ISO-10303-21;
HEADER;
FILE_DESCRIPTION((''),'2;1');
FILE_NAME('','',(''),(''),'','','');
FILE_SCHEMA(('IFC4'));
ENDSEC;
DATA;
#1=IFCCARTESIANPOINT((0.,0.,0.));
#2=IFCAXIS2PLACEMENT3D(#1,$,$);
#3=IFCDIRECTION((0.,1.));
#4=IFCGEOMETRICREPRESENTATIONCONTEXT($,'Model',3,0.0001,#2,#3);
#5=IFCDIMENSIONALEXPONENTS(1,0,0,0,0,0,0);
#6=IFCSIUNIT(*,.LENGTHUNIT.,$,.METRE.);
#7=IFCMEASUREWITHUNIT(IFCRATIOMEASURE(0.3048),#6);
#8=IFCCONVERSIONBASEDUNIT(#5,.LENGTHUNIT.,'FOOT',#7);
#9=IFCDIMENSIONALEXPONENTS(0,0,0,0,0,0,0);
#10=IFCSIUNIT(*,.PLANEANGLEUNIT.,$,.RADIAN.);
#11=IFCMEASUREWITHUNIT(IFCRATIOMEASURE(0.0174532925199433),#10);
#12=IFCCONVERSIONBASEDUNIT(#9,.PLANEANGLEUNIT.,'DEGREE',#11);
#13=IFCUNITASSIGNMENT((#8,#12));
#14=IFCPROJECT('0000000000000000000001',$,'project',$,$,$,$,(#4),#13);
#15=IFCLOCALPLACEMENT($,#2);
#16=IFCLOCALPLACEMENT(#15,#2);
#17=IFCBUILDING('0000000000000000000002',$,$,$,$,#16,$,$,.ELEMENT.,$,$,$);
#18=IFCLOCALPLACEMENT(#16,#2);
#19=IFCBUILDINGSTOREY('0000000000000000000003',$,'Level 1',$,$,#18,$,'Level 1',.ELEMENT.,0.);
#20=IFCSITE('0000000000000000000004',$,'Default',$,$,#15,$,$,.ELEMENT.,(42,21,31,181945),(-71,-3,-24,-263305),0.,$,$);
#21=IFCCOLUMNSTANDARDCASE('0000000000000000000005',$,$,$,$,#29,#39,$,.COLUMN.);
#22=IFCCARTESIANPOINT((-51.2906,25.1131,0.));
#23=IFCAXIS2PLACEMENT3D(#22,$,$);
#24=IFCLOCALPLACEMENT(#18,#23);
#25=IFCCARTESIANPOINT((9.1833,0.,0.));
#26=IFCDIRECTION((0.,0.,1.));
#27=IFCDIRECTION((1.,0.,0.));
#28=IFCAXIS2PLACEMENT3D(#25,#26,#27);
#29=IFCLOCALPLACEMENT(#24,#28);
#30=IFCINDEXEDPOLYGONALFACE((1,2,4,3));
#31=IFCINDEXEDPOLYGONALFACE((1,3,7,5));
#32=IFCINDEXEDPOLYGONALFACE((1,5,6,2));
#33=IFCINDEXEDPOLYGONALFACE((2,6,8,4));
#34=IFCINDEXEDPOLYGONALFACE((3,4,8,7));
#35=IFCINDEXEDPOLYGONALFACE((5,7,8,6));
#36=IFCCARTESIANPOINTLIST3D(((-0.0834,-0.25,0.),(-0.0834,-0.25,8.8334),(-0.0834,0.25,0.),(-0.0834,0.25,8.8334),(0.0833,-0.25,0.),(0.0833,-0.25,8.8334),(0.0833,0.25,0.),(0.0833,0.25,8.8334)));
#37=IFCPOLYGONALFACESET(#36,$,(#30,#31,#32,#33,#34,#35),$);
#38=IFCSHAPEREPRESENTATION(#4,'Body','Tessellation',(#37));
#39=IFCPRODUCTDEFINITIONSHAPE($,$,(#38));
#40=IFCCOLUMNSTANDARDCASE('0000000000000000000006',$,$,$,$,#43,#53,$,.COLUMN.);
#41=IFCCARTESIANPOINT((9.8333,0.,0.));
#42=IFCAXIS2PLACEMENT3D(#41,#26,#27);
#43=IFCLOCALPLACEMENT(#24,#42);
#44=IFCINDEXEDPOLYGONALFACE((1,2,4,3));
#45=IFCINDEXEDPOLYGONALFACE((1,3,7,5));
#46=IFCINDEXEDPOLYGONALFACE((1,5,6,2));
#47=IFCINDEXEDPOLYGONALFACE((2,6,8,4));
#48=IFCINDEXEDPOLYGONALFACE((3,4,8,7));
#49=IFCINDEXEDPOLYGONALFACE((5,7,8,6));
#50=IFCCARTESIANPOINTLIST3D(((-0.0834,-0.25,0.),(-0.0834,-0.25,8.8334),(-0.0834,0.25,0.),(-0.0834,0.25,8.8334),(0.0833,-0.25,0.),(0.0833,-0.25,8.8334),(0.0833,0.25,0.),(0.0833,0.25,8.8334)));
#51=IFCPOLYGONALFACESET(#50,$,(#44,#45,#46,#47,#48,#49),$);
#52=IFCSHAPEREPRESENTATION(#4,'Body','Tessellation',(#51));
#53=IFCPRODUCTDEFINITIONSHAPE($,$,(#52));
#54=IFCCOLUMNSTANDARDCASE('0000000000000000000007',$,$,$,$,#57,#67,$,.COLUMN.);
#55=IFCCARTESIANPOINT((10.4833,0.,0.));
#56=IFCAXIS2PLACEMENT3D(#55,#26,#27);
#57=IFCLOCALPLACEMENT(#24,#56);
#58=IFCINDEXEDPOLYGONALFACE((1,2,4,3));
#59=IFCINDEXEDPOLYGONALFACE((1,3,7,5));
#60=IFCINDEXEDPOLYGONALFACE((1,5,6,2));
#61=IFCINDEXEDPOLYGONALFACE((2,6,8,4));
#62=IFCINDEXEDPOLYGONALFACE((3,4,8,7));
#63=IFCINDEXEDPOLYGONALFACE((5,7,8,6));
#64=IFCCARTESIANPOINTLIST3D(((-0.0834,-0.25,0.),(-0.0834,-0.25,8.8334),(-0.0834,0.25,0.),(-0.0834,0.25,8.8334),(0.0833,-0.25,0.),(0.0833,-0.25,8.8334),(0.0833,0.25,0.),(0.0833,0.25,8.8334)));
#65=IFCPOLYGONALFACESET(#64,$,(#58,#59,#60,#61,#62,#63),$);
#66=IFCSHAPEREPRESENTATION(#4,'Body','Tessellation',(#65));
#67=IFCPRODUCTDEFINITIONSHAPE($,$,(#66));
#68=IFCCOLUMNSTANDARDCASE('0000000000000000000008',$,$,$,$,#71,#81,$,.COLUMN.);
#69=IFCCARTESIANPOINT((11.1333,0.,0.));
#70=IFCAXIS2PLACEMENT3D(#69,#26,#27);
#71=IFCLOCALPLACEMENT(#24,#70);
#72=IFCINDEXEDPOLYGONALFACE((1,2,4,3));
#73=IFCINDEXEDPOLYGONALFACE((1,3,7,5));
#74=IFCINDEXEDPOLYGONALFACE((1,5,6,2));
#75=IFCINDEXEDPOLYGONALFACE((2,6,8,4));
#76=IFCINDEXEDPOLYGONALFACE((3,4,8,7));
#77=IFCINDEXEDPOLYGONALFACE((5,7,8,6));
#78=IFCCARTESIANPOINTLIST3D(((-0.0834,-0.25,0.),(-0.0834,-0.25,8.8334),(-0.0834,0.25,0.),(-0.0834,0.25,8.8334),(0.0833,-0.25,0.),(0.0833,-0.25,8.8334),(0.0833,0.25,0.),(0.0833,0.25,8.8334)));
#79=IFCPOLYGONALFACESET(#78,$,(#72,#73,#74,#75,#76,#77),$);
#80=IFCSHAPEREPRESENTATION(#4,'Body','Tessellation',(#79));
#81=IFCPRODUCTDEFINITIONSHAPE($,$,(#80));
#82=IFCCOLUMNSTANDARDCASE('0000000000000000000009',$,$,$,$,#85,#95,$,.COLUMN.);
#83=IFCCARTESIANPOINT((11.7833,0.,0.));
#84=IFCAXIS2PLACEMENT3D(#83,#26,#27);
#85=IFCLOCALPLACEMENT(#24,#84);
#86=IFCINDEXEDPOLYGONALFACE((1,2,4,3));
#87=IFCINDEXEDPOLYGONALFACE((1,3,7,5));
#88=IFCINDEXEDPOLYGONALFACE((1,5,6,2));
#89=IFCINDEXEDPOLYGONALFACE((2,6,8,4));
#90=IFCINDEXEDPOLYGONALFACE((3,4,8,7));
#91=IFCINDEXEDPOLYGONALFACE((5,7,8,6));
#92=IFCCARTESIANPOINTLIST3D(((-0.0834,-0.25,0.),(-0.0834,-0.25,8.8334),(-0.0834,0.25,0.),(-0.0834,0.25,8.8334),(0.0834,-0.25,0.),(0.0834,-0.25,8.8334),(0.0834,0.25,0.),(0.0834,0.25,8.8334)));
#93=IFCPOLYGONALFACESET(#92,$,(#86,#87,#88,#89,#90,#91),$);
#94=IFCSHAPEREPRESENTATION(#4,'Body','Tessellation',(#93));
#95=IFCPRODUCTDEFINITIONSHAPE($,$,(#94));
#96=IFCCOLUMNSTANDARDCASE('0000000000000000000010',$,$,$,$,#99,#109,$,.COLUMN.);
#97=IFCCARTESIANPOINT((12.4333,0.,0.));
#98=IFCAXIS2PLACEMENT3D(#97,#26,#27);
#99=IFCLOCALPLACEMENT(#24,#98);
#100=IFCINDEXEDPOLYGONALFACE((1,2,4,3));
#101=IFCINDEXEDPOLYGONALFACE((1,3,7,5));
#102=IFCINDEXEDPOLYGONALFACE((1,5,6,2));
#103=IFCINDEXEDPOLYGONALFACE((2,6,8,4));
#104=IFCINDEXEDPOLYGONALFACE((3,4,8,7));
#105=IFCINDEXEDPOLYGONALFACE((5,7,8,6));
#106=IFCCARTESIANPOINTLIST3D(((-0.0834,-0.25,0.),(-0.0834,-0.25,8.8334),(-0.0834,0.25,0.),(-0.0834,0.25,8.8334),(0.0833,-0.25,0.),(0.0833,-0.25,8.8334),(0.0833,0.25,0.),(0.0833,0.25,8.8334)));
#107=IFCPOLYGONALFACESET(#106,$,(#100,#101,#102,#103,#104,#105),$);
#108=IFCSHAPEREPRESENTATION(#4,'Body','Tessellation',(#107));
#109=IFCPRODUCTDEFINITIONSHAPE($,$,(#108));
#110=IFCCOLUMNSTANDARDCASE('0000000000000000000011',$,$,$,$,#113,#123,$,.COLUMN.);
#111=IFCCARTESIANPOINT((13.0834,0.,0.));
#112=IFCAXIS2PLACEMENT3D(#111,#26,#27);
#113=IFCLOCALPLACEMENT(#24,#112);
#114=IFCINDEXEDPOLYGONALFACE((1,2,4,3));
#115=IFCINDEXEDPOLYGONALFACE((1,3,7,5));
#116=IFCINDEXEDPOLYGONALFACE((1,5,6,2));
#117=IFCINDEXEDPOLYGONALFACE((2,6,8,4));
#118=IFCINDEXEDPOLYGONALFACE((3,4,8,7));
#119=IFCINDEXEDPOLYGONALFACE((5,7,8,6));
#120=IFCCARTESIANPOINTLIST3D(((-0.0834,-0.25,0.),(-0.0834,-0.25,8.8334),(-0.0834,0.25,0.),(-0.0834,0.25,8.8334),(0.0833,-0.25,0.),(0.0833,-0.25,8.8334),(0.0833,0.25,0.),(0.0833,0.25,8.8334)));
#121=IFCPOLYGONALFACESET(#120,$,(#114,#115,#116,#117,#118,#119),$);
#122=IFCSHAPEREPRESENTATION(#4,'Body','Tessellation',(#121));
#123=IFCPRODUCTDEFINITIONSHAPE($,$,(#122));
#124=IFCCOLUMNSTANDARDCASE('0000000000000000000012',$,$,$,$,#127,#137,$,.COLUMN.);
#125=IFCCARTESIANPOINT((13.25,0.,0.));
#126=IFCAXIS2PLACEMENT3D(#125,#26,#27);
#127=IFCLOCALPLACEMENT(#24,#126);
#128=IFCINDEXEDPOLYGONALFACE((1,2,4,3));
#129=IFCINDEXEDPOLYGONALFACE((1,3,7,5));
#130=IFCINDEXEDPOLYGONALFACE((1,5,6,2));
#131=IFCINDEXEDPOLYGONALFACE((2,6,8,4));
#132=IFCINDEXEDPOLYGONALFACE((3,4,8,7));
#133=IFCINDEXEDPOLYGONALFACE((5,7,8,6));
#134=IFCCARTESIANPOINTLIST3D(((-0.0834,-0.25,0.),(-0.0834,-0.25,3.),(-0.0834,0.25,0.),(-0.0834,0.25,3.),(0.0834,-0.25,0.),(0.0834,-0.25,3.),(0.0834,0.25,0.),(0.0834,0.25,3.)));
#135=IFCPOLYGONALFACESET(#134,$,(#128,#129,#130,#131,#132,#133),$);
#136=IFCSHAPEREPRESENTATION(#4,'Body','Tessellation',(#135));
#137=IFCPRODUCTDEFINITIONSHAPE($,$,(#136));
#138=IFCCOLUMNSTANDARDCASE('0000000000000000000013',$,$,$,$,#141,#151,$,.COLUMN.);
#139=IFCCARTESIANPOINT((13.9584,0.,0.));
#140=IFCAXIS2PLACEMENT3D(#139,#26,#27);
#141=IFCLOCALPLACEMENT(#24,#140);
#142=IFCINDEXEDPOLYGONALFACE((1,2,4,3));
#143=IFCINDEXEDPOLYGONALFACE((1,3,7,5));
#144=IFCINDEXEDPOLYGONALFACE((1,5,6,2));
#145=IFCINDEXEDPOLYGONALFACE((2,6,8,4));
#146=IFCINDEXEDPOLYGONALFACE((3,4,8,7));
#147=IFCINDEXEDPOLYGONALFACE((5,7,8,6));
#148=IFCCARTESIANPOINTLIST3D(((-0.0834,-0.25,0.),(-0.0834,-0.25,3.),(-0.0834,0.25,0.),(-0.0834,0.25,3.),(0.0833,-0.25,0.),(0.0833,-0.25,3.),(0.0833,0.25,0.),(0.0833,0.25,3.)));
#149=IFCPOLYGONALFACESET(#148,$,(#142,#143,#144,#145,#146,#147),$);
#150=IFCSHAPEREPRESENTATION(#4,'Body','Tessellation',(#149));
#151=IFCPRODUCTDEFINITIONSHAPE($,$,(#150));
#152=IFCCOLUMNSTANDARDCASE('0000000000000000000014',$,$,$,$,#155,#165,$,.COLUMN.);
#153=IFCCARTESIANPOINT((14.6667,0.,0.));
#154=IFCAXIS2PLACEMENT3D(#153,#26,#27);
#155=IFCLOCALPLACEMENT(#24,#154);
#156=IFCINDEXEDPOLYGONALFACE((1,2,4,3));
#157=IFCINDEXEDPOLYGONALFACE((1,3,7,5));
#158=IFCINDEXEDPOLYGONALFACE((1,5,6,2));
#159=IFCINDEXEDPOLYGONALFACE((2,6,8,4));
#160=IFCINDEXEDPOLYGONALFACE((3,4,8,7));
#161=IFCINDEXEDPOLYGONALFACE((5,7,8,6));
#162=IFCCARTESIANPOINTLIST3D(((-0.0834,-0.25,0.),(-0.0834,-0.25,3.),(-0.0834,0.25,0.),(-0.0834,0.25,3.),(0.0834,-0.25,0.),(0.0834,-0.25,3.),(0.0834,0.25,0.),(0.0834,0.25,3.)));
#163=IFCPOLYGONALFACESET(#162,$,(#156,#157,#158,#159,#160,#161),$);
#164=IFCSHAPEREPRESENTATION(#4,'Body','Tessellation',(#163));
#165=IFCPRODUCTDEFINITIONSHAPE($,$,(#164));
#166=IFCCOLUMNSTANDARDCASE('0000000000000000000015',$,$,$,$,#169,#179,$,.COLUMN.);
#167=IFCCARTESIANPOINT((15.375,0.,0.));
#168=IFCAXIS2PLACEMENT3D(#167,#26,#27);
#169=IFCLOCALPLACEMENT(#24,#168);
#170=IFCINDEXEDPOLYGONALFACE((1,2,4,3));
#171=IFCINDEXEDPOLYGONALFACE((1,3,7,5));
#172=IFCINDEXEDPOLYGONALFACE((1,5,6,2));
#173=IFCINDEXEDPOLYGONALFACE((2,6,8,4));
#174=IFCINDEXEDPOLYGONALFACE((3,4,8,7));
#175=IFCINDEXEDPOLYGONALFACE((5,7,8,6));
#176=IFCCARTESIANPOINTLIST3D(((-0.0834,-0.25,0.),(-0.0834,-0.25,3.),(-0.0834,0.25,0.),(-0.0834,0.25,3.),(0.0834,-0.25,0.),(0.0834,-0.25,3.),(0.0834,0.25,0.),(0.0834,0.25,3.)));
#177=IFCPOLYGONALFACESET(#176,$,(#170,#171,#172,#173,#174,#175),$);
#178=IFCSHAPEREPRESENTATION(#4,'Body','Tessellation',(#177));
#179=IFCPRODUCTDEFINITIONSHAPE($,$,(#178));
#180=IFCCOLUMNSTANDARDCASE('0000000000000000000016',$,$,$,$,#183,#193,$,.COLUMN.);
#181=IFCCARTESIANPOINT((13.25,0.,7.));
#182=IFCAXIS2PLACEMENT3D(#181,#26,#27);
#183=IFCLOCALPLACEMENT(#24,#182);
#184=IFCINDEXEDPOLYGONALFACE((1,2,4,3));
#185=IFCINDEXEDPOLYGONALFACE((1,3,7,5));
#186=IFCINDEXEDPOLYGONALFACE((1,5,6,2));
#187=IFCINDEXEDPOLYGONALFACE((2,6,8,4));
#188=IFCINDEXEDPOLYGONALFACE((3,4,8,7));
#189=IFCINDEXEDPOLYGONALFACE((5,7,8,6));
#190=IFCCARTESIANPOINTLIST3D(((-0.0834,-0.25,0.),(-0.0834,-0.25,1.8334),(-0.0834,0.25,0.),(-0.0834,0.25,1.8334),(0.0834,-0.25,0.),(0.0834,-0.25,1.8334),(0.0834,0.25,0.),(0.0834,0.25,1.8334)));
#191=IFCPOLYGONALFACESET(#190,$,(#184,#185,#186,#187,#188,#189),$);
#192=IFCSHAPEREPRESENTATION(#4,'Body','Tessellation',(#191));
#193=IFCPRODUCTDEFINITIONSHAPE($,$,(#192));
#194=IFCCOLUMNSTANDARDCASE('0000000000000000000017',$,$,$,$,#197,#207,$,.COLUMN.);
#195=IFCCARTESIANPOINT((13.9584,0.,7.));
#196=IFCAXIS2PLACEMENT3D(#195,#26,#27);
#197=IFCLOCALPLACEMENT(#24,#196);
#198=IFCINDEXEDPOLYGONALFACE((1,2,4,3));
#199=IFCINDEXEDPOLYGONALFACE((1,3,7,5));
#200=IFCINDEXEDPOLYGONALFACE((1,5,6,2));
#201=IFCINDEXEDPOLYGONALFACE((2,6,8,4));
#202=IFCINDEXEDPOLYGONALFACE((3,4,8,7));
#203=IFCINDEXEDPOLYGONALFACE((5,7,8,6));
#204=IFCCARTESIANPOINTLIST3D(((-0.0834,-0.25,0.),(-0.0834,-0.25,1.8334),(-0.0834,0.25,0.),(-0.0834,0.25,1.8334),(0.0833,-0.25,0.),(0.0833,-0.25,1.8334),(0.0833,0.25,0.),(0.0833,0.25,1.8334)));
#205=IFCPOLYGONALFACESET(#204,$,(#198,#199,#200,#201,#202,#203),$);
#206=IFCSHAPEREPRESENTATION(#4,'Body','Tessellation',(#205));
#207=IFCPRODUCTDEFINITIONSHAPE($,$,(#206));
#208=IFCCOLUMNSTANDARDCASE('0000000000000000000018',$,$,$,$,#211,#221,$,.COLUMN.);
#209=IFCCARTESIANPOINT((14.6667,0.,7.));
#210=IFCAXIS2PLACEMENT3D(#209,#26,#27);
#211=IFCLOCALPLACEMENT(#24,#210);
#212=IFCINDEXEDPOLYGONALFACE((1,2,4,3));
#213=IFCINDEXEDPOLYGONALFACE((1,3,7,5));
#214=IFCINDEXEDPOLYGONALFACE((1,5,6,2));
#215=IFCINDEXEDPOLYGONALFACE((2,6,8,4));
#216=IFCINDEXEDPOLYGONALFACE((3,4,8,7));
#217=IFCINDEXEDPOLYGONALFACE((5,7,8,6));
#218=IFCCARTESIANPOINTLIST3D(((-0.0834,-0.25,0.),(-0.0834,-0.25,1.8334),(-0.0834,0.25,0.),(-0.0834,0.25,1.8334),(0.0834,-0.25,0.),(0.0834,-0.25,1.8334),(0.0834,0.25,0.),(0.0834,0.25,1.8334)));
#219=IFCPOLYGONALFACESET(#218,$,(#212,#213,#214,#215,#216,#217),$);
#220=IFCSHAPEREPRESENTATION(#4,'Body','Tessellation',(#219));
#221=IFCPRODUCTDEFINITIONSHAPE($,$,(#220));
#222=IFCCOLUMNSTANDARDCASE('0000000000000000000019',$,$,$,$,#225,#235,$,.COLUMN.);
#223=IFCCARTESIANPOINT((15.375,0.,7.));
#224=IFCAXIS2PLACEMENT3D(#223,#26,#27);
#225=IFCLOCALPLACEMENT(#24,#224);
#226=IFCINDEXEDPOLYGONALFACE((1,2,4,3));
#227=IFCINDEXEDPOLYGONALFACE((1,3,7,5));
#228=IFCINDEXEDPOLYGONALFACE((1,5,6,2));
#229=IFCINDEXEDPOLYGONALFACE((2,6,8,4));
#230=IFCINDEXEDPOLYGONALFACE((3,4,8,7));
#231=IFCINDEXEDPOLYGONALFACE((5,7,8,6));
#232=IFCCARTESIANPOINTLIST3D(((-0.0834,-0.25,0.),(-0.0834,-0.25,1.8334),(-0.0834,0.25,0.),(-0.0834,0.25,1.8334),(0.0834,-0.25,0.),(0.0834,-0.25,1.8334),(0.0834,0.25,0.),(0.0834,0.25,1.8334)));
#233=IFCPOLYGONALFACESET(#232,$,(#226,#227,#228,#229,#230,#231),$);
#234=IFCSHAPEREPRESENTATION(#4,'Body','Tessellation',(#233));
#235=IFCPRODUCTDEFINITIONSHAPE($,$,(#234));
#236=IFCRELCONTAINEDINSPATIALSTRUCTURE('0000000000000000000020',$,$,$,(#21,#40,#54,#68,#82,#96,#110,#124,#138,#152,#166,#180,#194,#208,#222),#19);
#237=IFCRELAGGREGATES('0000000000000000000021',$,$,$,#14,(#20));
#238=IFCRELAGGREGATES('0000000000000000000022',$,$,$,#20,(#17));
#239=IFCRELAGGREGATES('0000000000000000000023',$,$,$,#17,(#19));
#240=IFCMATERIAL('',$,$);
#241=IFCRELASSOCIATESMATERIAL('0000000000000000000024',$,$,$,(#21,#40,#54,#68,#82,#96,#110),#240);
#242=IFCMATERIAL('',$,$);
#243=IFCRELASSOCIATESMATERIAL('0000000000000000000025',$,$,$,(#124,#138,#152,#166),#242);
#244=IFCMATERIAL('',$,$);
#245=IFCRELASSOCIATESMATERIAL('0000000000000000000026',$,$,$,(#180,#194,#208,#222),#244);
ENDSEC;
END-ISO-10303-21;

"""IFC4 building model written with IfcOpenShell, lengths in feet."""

from ifc_helpers import new_model, entity, si_unit, converted_unit, direction, frame, origin, place, context, project, spatial, rectangle, extrude, material, element, save


model = new_model("IFC4")

# Units and contexts
model_context = context("Model", 3, precision=0.0001, world=origin(), true_north=direction((0.0, 1.0)))
ifc_project = project(units=[converted_unit("LENGTHUNIT", "FOOT", entity("IfcRatioMeasure", 0.3048), si_unit("LENGTHUNIT", "METRE"), dimensions=[1, 0, 0, 0, 0, 0, 0]), converted_unit("PLANEANGLEUNIT", "DEGREE", entity("IfcRatioMeasure", 0.0174532925199433), si_unit("PLANEANGLEUNIT", "RADIAN"), dimensions=[0, 0, 0, 0, 0, 0, 0])], contexts=[model_context])

# Site, building, storey
site_placement = place(None, origin())
site = spatial("IfcSite", under=ifc_project, at=site_placement, Name="Default", CompositionType="ELEMENT", RefLatitude=(42, 21, 31, 181945), RefLongitude=(-71, -3, -24, -263305), RefElevation=0.0)
building_placement = place(site_placement, origin())
building = spatial("IfcBuilding", under=site, at=building_placement, CompositionType="ELEMENT")
storey_placement = place(building_placement, origin())
storey = spatial("IfcBuildingStorey", under=building, at=storey_placement, Name="Level 1", LongName="Level 1", CompositionType="ELEMENT", Elevation=0.0)

# Columns
ifc_material_1 = material(Name="")
placement_1 = place(storey_placement, frame((-51.2906, 25.1131, 0.0)))
for number, where, z_axis, x_axis in (
    (1, (9.1833, 0.0, 0.0), (0.0, 0.0, 1.0), (1.0, 0.0, 0.0)),
    (2, (9.8333, 0.0, 0.0), (0.0, 0.0, 1.0), (1.0, 0.0, 0.0)),
    (3, (10.4833, 0.0, 0.0), (0.0, 0.0, 1.0), (1.0, 0.0, 0.0)),
    (4, (11.1333, 0.0, 0.0), (0.0, 0.0, 1.0), (1.0, 0.0, 0.0)),
    (5, (11.7833, 0.0, 0.0), (0.0, 0.0, 1.0), (1.0, 0.0, 0.0)),
    (6, (12.4333, 0.0, 0.0), (0.0, 0.0, 1.0), (1.0, 0.0, 0.0)),
    (7, (13.0834, 0.0, 0.0), (0.0, 0.0, 1.0), (1.0, 0.0, 0.0)),
):
    element("IfcColumnStandardCase", number, at=place(placement_1, frame(where, z_axis=z_axis, x_axis=x_axis)), inside=storey, material=ifc_material_1, PredefinedType="COLUMN", context=model_context, shape_type="SweptSolid", body=[
        extrude(rectangle(XDim=0.1667, YDim=0.5), origin(), (0.0, 0.0, 1.0), 8.8334),
    ])
ifc_material_2 = material(Name="")
for number, where, z_axis, x_axis in (
    (8, (13.25, 0.0, 0.0), (0.0, 0.0, 1.0), (1.0, 0.0, 0.0)),
    (9, (13.9584, 0.0, 0.0), (0.0, 0.0, 1.0), (1.0, 0.0, 0.0)),
    (10, (14.6667, 0.0, 0.0), (0.0, 0.0, 1.0), (1.0, 0.0, 0.0)),
    (11, (15.375, 0.0, 0.0), (0.0, 0.0, 1.0), (1.0, 0.0, 0.0)),
):
    element("IfcColumnStandardCase", number, at=place(placement_1, frame(where, z_axis=z_axis, x_axis=x_axis)), inside=storey, material=ifc_material_2, PredefinedType="COLUMN", context=model_context, shape_type="SweptSolid", body=[
        extrude(rectangle(XDim=0.1667, YDim=0.5), origin(), (0.0, 0.0, 1.0), 3.0),
    ])
ifc_material_3 = material(Name="")
for number, where, z_axis, x_axis in (
    (12, (13.25, 0.0, 7.0), (0.0, 0.0, 1.0), (1.0, 0.0, 0.0)),
    (13, (13.9584, 0.0, 7.0), (0.0, 0.0, 1.0), (1.0, 0.0, 0.0)),
    (14, (14.6667, 0.0, 7.0), (0.0, 0.0, 1.0), (1.0, 0.0, 0.0)),
    (15, (15.375, 0.0, 7.0), (0.0, 0.0, 1.0), (1.0, 0.0, 0.0)),
):
    element("IfcColumnStandardCase", number, at=place(placement_1, frame(where, z_axis=z_axis, x_axis=x_axis)), inside=storey, material=ifc_material_3, PredefinedType="COLUMN", context=model_context, shape_type="SweptSolid", body=[
        extrude(rectangle(XDim=0.1667, YDim=0.5), origin(), (0.0, 0.0, 1.0), 1.8334),
    ])

save(model, "model.ifc")
